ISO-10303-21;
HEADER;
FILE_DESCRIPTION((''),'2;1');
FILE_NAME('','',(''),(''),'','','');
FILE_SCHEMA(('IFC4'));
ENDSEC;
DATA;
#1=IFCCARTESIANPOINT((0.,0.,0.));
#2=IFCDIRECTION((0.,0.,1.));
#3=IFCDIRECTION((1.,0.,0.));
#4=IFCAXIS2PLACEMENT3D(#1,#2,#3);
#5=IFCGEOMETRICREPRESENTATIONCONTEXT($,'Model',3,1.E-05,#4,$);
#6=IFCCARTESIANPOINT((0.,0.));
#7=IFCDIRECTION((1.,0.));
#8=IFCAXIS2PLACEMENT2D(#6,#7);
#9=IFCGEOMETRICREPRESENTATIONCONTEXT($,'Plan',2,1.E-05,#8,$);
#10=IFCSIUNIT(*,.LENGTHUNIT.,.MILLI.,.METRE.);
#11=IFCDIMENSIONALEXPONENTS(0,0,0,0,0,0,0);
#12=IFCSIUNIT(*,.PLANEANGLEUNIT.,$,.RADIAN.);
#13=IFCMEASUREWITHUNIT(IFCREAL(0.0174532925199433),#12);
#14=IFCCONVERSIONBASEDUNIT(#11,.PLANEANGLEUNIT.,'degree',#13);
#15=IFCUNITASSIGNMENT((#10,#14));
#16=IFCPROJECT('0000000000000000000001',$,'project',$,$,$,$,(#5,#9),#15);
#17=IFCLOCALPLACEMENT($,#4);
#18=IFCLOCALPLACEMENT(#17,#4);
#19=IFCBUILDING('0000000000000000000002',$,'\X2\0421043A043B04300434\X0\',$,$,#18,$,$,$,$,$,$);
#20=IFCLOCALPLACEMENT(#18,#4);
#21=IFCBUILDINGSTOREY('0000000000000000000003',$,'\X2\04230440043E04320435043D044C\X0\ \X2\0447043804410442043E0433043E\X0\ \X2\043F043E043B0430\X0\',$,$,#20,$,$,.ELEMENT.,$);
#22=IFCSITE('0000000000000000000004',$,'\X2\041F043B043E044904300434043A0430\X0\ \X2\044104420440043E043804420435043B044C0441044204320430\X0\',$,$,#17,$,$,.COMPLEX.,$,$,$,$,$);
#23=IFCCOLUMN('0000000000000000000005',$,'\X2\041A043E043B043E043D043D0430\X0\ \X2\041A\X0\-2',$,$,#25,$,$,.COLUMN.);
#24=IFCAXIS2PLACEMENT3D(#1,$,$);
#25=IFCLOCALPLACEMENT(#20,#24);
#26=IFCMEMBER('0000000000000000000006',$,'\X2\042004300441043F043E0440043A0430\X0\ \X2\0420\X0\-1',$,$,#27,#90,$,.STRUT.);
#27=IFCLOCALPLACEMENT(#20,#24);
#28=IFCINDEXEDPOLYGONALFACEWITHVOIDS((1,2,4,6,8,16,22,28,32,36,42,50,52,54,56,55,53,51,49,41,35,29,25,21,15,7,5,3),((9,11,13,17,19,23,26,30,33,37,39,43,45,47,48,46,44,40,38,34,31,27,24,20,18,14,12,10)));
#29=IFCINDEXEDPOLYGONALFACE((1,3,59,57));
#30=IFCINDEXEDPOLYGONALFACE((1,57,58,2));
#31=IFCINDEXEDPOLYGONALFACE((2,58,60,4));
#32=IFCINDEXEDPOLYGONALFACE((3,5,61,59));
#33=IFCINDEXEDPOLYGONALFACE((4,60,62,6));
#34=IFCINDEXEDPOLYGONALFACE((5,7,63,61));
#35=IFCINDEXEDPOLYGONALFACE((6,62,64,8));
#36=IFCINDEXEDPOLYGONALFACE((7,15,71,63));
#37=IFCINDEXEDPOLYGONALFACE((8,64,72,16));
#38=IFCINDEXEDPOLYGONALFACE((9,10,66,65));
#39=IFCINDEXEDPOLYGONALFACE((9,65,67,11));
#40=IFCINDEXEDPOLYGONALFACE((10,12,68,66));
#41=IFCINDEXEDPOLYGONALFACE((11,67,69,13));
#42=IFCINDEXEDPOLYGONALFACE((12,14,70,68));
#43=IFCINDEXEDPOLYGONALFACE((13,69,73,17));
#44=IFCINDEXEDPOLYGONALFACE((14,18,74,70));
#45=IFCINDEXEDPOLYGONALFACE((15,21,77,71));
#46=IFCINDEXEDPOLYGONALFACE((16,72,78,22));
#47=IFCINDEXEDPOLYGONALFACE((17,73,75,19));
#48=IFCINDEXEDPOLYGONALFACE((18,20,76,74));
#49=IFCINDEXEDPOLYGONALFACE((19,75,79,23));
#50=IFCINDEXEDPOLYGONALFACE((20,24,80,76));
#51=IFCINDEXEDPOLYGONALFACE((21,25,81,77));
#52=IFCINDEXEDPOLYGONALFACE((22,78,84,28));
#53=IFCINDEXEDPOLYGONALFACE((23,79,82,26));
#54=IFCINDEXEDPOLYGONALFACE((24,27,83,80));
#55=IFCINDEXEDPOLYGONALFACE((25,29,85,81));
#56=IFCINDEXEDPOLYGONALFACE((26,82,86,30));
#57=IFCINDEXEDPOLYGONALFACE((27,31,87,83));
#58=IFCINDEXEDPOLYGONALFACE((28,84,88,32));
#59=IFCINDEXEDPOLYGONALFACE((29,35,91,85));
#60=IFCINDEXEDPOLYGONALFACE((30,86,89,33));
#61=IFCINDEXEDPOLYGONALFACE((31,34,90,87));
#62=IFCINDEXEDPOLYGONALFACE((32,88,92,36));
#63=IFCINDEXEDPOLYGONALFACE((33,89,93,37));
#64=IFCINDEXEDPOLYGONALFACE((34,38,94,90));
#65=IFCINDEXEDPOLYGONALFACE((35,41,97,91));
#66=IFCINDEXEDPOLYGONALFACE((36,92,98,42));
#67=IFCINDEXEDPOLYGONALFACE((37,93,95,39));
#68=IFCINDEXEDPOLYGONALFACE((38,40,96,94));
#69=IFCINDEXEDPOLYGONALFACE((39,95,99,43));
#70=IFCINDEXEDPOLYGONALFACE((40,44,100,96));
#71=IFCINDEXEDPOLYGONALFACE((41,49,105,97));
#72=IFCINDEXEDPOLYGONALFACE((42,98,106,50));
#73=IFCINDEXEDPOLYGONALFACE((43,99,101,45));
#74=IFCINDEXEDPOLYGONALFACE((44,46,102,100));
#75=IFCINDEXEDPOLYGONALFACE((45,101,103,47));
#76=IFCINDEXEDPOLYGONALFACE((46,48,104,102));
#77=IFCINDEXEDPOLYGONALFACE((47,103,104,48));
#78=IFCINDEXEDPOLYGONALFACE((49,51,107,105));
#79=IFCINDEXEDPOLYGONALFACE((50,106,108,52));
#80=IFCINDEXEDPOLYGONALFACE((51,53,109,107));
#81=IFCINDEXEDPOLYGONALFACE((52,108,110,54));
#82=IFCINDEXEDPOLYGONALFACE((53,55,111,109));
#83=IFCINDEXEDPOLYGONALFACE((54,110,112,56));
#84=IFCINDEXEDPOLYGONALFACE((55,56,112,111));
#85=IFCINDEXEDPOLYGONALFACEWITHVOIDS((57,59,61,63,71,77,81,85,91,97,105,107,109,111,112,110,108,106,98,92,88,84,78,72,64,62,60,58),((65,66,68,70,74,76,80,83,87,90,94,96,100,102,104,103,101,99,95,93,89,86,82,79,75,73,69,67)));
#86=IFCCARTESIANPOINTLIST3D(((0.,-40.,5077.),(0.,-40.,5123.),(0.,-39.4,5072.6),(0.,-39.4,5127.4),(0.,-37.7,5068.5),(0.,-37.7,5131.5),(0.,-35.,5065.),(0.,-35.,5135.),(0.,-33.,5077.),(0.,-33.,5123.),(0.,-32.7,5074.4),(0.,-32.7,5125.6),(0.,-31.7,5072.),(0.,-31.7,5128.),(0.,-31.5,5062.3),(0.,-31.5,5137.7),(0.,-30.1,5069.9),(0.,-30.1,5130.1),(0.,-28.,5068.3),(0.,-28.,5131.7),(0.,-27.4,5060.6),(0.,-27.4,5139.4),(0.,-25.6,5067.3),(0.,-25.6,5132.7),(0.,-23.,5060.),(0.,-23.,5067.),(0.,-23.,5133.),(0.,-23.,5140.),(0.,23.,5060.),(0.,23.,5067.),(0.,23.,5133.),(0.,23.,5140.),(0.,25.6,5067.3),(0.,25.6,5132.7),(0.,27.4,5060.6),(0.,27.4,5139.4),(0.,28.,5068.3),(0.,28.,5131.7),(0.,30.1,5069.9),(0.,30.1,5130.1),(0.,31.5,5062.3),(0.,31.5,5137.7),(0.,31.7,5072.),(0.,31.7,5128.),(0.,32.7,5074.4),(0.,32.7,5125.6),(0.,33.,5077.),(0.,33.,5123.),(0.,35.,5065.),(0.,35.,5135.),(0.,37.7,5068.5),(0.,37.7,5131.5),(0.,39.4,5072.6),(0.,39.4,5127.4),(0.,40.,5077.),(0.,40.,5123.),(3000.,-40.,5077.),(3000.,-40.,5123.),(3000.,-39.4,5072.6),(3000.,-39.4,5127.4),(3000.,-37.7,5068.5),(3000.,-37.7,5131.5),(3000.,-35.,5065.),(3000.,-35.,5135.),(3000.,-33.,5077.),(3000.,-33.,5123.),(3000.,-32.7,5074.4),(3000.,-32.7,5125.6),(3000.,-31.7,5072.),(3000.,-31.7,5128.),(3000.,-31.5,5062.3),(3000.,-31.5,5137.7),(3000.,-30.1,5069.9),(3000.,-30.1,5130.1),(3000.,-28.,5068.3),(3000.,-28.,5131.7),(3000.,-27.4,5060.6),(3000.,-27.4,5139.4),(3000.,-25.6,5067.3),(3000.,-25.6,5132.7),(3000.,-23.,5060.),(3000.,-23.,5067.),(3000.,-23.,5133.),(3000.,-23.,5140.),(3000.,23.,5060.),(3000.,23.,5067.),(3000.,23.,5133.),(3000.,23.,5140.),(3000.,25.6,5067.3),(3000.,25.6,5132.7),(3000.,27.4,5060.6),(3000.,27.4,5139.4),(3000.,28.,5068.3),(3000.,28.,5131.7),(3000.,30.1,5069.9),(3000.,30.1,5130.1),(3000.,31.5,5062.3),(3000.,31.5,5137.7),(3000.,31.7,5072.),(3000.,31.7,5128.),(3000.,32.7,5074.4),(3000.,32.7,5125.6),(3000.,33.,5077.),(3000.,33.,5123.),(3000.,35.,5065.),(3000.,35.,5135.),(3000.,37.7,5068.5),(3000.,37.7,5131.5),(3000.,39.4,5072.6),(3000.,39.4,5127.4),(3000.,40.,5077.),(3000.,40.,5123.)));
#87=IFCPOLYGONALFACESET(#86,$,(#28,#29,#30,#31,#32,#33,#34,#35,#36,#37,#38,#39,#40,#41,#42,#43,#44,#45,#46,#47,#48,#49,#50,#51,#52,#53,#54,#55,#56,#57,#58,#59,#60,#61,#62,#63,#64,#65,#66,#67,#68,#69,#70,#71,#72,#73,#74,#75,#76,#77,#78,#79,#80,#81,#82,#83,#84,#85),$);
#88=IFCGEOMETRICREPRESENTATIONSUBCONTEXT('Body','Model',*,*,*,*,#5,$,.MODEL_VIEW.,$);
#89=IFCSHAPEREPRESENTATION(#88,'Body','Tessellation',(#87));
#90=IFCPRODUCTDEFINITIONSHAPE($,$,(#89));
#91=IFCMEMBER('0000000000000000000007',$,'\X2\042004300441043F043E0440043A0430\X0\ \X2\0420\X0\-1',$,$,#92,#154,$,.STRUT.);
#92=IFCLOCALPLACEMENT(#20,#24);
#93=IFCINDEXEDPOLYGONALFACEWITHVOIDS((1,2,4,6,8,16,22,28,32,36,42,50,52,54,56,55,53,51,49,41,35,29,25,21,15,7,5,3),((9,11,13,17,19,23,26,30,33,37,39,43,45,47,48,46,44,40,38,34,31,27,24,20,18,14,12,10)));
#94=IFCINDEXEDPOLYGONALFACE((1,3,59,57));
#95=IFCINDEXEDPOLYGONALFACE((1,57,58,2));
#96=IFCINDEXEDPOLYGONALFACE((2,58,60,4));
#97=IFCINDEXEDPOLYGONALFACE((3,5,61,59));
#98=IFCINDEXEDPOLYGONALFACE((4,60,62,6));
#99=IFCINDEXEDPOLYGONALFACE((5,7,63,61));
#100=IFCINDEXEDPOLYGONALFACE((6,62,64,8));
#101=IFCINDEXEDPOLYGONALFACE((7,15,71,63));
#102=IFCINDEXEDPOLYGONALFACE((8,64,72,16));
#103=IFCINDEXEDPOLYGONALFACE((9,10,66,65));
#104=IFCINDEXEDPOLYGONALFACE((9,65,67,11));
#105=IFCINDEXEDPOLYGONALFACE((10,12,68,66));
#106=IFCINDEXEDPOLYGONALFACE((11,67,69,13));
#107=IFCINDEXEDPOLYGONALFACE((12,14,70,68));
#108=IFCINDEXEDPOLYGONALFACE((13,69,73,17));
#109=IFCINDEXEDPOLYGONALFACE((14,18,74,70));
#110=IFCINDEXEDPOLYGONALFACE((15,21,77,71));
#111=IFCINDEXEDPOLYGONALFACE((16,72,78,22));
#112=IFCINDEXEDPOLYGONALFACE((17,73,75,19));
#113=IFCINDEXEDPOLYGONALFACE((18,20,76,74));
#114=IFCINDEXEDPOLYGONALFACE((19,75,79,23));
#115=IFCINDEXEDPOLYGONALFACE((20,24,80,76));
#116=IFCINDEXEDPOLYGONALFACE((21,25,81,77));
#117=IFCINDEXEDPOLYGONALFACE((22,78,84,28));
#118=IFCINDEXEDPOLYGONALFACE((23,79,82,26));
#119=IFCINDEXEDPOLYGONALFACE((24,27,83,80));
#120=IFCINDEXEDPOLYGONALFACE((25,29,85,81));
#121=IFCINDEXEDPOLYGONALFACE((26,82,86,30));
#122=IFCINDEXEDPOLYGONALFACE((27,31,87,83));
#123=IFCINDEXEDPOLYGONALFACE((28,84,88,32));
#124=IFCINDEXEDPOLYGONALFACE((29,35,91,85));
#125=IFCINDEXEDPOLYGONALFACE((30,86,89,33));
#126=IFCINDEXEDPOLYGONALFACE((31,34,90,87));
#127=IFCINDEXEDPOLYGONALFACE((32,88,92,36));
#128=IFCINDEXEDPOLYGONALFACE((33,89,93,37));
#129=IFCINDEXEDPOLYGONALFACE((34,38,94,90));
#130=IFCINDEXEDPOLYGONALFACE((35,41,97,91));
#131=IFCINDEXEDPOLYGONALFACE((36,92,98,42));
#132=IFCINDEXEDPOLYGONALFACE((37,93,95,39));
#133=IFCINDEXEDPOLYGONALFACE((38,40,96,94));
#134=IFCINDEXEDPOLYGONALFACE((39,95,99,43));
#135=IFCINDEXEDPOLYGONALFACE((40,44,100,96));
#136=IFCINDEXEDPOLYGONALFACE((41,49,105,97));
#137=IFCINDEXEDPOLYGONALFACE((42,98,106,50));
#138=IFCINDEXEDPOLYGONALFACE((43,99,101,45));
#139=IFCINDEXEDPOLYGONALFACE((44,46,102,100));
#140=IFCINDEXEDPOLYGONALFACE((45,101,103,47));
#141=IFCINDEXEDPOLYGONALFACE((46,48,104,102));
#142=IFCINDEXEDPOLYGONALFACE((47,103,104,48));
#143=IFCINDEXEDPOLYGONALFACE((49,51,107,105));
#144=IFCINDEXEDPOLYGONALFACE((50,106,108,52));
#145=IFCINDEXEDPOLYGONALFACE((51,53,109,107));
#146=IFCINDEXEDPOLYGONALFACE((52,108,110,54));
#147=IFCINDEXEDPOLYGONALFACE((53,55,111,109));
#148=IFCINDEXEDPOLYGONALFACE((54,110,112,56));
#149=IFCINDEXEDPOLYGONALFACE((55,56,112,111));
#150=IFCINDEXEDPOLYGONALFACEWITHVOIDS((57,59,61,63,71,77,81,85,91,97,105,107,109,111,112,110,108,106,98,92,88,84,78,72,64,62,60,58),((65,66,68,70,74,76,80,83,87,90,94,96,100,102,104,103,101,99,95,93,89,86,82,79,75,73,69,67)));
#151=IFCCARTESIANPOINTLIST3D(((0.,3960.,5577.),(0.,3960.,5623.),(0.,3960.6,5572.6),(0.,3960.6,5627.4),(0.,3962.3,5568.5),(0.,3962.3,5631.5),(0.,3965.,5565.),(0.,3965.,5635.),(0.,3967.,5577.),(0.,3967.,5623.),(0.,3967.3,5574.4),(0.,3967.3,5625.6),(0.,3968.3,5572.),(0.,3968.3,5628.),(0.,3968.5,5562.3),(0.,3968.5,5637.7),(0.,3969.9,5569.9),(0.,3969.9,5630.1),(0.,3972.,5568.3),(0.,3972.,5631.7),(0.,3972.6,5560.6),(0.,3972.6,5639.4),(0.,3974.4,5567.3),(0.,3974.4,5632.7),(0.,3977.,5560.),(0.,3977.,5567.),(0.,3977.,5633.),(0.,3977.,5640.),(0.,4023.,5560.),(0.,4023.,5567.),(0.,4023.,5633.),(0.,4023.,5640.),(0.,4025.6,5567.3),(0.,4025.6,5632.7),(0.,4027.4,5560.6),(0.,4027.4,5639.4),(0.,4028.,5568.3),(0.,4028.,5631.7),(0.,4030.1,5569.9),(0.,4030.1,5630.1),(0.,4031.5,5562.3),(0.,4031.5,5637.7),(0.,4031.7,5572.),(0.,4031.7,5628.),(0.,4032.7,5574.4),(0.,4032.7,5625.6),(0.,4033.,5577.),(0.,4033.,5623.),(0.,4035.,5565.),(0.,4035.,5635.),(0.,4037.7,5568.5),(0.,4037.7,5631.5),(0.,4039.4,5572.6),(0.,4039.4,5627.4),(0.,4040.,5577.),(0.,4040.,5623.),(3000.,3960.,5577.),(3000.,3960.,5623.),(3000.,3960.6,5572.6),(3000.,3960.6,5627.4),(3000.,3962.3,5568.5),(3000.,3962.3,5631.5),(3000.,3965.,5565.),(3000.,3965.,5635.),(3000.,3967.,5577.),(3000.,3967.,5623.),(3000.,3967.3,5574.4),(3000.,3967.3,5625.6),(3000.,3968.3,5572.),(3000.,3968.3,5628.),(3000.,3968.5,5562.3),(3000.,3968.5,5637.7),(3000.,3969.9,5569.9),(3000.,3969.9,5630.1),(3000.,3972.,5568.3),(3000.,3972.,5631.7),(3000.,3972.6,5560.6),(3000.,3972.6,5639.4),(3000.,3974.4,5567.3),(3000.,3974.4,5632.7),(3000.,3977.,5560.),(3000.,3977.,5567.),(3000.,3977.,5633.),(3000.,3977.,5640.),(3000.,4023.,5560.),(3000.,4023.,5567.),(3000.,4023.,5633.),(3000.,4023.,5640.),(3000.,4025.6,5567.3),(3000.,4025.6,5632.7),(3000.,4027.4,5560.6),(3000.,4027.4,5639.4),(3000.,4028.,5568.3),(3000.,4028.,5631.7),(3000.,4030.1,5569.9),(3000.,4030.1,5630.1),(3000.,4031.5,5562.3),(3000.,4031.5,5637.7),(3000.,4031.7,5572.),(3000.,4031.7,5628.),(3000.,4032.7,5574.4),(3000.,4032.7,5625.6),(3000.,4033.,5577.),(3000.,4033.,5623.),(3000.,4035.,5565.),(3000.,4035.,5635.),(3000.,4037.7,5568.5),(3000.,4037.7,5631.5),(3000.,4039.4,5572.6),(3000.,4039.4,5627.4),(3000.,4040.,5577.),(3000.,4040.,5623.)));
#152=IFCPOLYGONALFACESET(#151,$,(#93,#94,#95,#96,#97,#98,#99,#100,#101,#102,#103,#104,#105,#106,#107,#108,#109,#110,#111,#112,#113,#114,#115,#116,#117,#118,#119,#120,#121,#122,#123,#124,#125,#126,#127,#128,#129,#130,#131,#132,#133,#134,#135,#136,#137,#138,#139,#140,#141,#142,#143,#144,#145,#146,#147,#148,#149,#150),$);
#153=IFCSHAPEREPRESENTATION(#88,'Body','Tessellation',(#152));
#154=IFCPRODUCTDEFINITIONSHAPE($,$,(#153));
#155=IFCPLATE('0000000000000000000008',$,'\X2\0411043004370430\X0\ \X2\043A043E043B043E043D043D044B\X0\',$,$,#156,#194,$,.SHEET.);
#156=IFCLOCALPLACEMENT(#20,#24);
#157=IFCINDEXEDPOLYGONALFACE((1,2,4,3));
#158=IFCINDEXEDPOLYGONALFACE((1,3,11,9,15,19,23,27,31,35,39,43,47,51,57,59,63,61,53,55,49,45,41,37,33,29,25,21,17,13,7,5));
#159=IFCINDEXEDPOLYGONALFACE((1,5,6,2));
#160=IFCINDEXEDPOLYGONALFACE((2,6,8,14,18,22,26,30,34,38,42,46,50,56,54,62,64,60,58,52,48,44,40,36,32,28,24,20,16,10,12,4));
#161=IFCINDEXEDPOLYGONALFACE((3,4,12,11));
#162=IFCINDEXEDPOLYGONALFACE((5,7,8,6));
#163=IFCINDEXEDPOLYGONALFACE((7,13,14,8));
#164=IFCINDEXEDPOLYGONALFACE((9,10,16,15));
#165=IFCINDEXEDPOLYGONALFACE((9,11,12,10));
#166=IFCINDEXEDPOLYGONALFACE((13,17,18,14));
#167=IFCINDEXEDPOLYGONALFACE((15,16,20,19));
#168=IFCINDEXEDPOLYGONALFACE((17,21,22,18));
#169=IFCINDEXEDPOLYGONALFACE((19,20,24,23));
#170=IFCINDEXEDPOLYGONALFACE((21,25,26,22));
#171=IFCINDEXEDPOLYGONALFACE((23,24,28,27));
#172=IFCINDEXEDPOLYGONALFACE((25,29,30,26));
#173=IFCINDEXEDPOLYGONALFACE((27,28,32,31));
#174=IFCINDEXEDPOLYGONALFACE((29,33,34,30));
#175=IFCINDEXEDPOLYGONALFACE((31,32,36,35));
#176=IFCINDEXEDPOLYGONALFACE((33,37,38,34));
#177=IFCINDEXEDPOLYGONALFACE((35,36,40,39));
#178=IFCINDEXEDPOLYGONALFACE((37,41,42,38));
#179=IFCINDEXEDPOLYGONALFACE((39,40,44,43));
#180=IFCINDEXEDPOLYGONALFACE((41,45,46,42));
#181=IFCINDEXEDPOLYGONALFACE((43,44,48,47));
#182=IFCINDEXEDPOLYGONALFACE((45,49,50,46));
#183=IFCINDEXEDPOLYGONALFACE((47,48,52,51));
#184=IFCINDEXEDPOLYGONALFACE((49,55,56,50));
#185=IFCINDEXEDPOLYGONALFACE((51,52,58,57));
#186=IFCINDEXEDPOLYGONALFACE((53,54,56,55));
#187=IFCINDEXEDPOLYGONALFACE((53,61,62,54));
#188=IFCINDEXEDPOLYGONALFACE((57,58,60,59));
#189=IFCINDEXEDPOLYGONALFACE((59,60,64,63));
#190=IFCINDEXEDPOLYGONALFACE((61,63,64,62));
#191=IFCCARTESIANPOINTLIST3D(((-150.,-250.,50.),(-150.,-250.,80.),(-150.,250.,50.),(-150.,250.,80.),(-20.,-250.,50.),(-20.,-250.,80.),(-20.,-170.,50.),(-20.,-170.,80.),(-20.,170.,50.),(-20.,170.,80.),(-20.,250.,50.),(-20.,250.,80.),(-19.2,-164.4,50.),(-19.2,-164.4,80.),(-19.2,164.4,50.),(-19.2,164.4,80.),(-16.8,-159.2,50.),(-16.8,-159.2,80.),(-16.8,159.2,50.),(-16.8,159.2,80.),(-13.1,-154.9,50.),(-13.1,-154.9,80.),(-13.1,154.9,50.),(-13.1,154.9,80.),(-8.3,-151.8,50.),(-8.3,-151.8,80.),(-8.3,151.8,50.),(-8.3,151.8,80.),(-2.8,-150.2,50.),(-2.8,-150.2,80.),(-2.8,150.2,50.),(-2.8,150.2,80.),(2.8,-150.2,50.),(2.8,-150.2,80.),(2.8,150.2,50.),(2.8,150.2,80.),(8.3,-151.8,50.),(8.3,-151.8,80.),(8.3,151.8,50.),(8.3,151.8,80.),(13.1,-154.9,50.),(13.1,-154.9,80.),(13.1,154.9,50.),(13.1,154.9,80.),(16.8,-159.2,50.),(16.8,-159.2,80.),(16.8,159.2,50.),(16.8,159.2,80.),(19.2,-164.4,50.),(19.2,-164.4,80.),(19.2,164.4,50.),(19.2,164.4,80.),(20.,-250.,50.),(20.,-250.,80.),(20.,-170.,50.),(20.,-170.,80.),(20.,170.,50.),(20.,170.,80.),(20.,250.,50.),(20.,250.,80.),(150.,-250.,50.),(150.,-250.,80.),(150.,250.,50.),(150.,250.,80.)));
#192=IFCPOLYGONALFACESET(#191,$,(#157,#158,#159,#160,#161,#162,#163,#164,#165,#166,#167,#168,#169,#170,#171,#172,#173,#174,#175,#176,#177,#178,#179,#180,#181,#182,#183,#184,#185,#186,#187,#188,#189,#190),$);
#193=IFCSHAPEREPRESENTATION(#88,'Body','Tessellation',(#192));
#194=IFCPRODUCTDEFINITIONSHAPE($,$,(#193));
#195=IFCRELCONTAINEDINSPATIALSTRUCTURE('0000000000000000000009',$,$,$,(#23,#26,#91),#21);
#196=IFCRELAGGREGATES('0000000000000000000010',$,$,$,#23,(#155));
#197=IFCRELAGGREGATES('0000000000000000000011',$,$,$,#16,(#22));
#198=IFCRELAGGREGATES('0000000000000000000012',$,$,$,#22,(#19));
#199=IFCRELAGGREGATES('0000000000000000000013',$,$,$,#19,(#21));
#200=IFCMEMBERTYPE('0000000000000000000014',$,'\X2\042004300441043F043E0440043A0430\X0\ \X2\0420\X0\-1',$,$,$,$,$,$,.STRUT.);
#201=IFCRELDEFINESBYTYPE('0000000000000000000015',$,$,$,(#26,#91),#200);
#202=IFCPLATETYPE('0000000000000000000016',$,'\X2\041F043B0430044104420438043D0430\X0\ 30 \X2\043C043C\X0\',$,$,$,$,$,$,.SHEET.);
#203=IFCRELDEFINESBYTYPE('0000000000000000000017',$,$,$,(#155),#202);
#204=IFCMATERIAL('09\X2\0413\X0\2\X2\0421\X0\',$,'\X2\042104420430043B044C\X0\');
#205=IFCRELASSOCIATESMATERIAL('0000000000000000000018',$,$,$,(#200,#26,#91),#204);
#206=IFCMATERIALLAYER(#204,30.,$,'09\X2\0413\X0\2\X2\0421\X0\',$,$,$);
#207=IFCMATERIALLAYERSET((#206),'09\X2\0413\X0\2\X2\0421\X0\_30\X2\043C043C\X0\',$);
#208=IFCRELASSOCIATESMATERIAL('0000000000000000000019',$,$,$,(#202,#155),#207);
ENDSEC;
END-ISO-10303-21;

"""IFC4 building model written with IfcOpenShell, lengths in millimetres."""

from ifc_helpers import new_model, entity, si_unit, converted_unit, frame, origin_with_axes, origin_2d_with_axis, place, context, subcontext, project, spatial, line, arc, indexed_curve, hollow_rectangle, outline, extrude, material, layer, layer_set, layer_usage, material_profile, profile_set, profile_usage, type_object, element, aggregate, save


model = new_model("IFC4")

# Units and contexts
model_context = context("Model", 3, precision=1e-05, world=origin_with_axes())
plan_context = context("Plan", 2, precision=1e-05, world=origin_2d_with_axis())
body_context = subcontext(model_context, "Body", "Model", "MODEL_VIEW")
ifc_project = project(units=[si_unit("LENGTHUNIT", "METRE", prefix="MILLI"), converted_unit("PLANEANGLEUNIT", "degree", entity("IfcReal", 0.0174532925199433), si_unit("PLANEANGLEUNIT", "RADIAN"), dimensions=[0, 0, 0, 0, 0, 0, 0])], contexts=[model_context, plan_context])

# Site, building, storey
site_placement = place(None, origin_with_axes())
site = spatial("IfcSite", under=ifc_project, at=site_placement, Name="Площадка строительства", CompositionType="COMPLEX")
building_placement = place(site_placement, origin_with_axes())
building = spatial("IfcBuilding", under=site, at=building_placement, Name="Склад")
storey_placement = place(building_placement, origin_with_axes())
storey = spatial("IfcBuildingStorey", under=building, at=storey_placement, Name="Уровень чистого пола", CompositionType="ELEMENT")

# Column
column_1_placement = place(storey_placement, origin_with_axes())
column_1 = element("IfcColumn", 1, at=column_1_placement, inside=storey, Name="Колонна К-2", PredefinedType="COLUMN")

# Members
ifc_material_1 = material(Name="09Г2С", Category="Сталь")
ifc_material_profile_1 = material_profile(ifc_material_1, hollow_rectangle(XDim=80.0, YDim=80.0, WallThickness=7.0, InnerFilletRadius=10.0, OuterFilletRadius=17.0))
ifc_profile_set_1 = profile_set([ifc_material_profile_1], Name="PK80x7_09G2S")
ifc_profile_usage_1 = profile_usage(ifc_profile_set_1, cardinal=5)
member_type_1 = type_object("IfcMemberType", Name="Распорка Р-1", PredefinedType="STRUT", material=ifc_profile_set_1)
member_1_placement = place(storey_placement, frame((0.0, 0.0, 5100.0), z_axis=(1.0, 0.0, 0.0), x_axis=(0.0, 1.0, 0.0)))
element("IfcMember", 2, at=member_1_placement, inside=storey, type_object=member_type_1, material=ifc_profile_usage_1, Name="Распорка Р-1", PredefinedType="STRUT", context=body_context, shape_type="SweptSolid", body=[
    extrude(hollow_rectangle(XDim=80.0, YDim=80.0, WallThickness=7.0, InnerFilletRadius=10.0, OuterFilletRadius=17.0), origin_with_axes(), (0.0, 0.0, 1.0), 3000.0),
])
ifc_profile_usage_2 = profile_usage(ifc_profile_set_1, cardinal=5)
member_2_placement = place(storey_placement, frame((0.0, 4000.0, 5600.0), z_axis=(1.0, 0.0, 0.0), x_axis=(0.0, 1.0, 0.0)))
element("IfcMember", 3, at=member_2_placement, inside=storey, type_object=member_type_1, material=ifc_profile_usage_2, Name="Распорка Р-1", PredefinedType="STRUT", context=body_context, shape_type="SweptSolid", body=[
    extrude(hollow_rectangle(XDim=80.0, YDim=80.0, WallThickness=7.0, InnerFilletRadius=10.0, OuterFilletRadius=17.0), origin_with_axes(), (0.0, 0.0, 1.0), 3000.0),
])

# Plate
ifc_layer = layer(ifc_material_1, 30.0, Name="09Г2С")
ifc_layer_set = layer_set([ifc_layer], Name="09Г2С_30мм")
ifc_layer_usage = layer_usage(ifc_layer_set, "AXIS3", "POSITIVE", 0.0)
plate_type = type_object("IfcPlateType", Name="Пластина 30 мм", PredefinedType="SHEET", material=ifc_layer_set)
plate_placement = place(column_1_placement, frame((0.0, 0.0, 50.0), z_axis=(0.0, 0.0, 1.0), x_axis=(1.0, 0.0, 0.0)))
plate = element("IfcPlate", 4, at=plate_placement, type_object=plate_type, material=ifc_layer_usage, Name="База колонны", PredefinedType="SHEET", context=body_context, shape_type="SweptSolid", body=[
    extrude(outline(indexed_curve([(-20.0, -170.0), (0.0, -150.0), (20.0, -170.0), (20.0, -250.0), (150.0, -250.0), (150.0, 250.0), (20.0, 250.0), (20.0, 170.0), (0.0, 150.0), (-20.0, 170.0), (-20.0, 250.0), (-150.0, 250.0), (-150.0, -250.0), (-20.0, -250.0)], segments=[line(11, 12), line(12, 13), line(13, 14), line(14, 1), arc(1, 2, 3), line(3, 4), line(4, 5), line(5, 6), line(6, 7), line(7, 8), arc(8, 9, 10), line(10, 11)], self_intersect=False)), None, (0.0, 0.0, 1.0), 30.0),
])

aggregate(column_1, [plate])

save(model, "model.ifc")
